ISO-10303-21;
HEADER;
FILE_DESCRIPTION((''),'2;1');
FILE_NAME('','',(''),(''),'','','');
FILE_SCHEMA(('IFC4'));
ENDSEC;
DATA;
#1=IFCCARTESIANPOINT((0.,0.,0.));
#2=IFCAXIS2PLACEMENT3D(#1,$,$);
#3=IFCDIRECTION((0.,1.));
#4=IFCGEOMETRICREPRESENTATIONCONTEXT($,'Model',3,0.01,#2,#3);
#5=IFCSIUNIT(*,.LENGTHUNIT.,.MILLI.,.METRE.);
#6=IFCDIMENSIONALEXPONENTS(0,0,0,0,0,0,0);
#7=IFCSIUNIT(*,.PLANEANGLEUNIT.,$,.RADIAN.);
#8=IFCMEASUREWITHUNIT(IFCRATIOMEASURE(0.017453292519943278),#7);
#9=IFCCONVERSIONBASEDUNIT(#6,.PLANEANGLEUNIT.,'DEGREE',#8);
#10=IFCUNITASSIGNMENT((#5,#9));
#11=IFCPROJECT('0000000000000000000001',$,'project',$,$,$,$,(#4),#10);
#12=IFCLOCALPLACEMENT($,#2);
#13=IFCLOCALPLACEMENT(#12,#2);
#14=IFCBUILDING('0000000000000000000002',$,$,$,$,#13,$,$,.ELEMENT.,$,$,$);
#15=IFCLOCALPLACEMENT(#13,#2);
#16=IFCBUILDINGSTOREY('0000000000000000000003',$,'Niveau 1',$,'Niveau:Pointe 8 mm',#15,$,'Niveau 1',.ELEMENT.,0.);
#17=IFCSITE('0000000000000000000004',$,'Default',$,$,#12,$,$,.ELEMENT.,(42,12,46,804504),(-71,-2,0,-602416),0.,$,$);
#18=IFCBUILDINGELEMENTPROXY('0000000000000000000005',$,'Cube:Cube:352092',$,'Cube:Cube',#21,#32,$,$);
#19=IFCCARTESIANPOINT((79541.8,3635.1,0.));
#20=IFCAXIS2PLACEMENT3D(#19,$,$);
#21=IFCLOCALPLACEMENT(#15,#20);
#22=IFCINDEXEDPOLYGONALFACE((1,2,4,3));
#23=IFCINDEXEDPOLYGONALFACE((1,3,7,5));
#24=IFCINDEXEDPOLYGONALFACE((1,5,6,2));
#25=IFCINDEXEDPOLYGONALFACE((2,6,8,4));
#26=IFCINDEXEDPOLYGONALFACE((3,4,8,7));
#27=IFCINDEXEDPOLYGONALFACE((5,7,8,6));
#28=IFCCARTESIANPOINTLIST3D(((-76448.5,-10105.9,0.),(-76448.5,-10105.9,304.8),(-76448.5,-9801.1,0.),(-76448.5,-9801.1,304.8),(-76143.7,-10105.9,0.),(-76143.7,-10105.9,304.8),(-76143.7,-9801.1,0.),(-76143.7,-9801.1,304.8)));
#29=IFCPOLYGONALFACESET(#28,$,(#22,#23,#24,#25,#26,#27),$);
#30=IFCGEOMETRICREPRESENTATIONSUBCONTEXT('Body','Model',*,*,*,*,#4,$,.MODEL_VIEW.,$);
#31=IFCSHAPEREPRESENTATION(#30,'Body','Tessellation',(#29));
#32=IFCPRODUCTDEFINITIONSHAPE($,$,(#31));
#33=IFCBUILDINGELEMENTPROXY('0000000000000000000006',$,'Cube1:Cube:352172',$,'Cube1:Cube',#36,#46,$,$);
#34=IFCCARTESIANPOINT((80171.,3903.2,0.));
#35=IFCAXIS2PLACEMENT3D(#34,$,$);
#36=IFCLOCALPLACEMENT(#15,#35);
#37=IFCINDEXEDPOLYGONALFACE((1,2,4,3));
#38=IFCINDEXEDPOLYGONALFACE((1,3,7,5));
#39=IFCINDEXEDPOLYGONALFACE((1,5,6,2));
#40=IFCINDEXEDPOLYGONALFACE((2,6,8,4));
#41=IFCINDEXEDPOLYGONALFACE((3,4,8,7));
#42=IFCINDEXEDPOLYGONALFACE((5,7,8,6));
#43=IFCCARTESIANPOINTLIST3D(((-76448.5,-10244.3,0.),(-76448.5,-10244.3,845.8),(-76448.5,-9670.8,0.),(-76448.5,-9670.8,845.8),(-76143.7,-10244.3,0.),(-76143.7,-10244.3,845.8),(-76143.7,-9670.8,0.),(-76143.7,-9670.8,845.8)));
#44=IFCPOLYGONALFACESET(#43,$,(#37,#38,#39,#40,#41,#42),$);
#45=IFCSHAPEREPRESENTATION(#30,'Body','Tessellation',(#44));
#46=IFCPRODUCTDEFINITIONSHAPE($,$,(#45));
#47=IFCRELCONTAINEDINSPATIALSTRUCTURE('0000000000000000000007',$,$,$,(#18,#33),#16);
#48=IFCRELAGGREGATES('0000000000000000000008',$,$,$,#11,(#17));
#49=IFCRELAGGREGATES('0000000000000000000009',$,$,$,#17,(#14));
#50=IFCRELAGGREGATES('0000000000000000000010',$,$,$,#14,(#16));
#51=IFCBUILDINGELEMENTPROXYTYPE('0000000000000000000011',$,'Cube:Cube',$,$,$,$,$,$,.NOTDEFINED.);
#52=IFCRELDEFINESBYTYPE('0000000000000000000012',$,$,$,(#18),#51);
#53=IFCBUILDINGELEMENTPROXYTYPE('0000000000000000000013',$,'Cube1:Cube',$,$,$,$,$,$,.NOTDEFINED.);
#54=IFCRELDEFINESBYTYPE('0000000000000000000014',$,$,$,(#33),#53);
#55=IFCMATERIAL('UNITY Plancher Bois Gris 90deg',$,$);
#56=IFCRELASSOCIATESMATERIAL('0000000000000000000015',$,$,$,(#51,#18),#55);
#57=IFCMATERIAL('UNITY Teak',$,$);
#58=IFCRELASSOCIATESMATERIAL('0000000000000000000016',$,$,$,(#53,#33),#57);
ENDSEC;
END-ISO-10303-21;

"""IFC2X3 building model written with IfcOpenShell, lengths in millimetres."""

from ifc_helpers import new_model, entity, si_unit, converted_unit, direction, frame, frame_2d, origin, origin_2d_with_axis, place, context, subcontext, project, spatial, rectangle, extrude, source, transform, mapped, material, type_object, type_shapes, element, save


model = new_model("IFC2X3")

# Units and contexts
model_context = context("Model", 3, precision=0.01, world=origin(), true_north=direction((0.0, 1.0)))
body_context = subcontext(model_context, "Body", "Model", "MODEL_VIEW")
ifc_project = project(units=[si_unit("LENGTHUNIT", "METRE", prefix="MILLI"), converted_unit("PLANEANGLEUNIT", "DEGREE", entity("IfcRatioMeasure", 0.017453292519943278), si_unit("PLANEANGLEUNIT", "RADIAN"), dimensions=[0, 0, 0, 0, 0, 0, 0])], contexts=[model_context])

# Site, building, storey
site_placement = place(None, origin())
site = spatial("IfcSite", under=ifc_project, at=site_placement, Name="Default", CompositionType="ELEMENT", RefLatitude=(42, 12, 46, 804504), RefLongitude=(-71, -2, 0, -602416), RefElevation=0.0)
building_placement = place(site_placement, origin())
building = spatial("IfcBuilding", under=site, at=building_placement, CompositionType="ELEMENT")
storey_placement = place(building_placement, origin())
storey = spatial("IfcBuildingStorey", under=building, at=storey_placement, Name="Niveau 1", ObjectType="Niveau:Pointe 8 mm", LongName="Niveau 1", CompositionType="ELEMENT", Elevation=0.0)

# Shared definitions
ifc_material_1 = material(Name="UNITY Plancher Bois Gris 90deg")

# Building element proxies
building_element_proxy_type_1 = type_object("IfcBuildingElementProxyType", Name="Cube:Cube", PredefinedType="NOTDEFINED", material=ifc_material_1)
shared_shape_1 = source(origin(), body_context, "Body", "SweptSolid", [
    extrude(rectangle(XDim=304.8, YDim=304.8, at=origin_2d_with_axis()), frame((-76296.1, -9953.5, 0.0), z_axis=(0.0, 0.0, 1.0), x_axis=(0.0, -1.0, 0.0)), (0.0, 0.0, 1.0), 304.8),
])
type_shapes(building_element_proxy_type_1, [shared_shape_1])
proxy_1_placement = place(storey_placement, frame((79541.8, 3635.1, 0.0)))
element("IfcBuildingElementProxy", 1, at=proxy_1_placement, inside=storey, type_object=building_element_proxy_type_1, material=ifc_material_1, Name="Cube:Cube:352092", ObjectType="Cube:Cube", context=body_context, shape_type="MappedRepresentation", body=[
    mapped(shared_shape_1, transform((0.0, 0.0, 0.0), scale=1.0)),
])
ifc_material_2 = material(Name="UNITY Teak")
building_element_proxy_type_2 = type_object("IfcBuildingElementProxyType", Name="Cube1:Cube", PredefinedType="NOTDEFINED", material=ifc_material_2)
shared_shape_2 = source(origin(), body_context, "Body", "SweptSolid", [
    extrude(rectangle(XDim=573.5, YDim=304.8, at=frame_2d((0.0, 0.0), x_axis=(1.0, 0.0))), frame((-76296.1, -9957.5, 0.0), z_axis=(0.0, 0.0, 1.0), x_axis=(0.0, -1.0, 0.0)), (0.0, 0.0, 1.0), 845.8),
])
type_shapes(building_element_proxy_type_2, [shared_shape_2])
proxy_2_placement = place(storey_placement, frame((80171.0, 3903.2, 0.0)))
element("IfcBuildingElementProxy", 2, at=proxy_2_placement, inside=storey, type_object=building_element_proxy_type_2, material=ifc_material_2, Name="Cube1:Cube:352172", ObjectType="Cube1:Cube", context=body_context, shape_type="MappedRepresentation", body=[
    mapped(shared_shape_2, transform((0.0, 0.0, 0.0), scale=1.0)),
])

save(model, "model.ifc")
